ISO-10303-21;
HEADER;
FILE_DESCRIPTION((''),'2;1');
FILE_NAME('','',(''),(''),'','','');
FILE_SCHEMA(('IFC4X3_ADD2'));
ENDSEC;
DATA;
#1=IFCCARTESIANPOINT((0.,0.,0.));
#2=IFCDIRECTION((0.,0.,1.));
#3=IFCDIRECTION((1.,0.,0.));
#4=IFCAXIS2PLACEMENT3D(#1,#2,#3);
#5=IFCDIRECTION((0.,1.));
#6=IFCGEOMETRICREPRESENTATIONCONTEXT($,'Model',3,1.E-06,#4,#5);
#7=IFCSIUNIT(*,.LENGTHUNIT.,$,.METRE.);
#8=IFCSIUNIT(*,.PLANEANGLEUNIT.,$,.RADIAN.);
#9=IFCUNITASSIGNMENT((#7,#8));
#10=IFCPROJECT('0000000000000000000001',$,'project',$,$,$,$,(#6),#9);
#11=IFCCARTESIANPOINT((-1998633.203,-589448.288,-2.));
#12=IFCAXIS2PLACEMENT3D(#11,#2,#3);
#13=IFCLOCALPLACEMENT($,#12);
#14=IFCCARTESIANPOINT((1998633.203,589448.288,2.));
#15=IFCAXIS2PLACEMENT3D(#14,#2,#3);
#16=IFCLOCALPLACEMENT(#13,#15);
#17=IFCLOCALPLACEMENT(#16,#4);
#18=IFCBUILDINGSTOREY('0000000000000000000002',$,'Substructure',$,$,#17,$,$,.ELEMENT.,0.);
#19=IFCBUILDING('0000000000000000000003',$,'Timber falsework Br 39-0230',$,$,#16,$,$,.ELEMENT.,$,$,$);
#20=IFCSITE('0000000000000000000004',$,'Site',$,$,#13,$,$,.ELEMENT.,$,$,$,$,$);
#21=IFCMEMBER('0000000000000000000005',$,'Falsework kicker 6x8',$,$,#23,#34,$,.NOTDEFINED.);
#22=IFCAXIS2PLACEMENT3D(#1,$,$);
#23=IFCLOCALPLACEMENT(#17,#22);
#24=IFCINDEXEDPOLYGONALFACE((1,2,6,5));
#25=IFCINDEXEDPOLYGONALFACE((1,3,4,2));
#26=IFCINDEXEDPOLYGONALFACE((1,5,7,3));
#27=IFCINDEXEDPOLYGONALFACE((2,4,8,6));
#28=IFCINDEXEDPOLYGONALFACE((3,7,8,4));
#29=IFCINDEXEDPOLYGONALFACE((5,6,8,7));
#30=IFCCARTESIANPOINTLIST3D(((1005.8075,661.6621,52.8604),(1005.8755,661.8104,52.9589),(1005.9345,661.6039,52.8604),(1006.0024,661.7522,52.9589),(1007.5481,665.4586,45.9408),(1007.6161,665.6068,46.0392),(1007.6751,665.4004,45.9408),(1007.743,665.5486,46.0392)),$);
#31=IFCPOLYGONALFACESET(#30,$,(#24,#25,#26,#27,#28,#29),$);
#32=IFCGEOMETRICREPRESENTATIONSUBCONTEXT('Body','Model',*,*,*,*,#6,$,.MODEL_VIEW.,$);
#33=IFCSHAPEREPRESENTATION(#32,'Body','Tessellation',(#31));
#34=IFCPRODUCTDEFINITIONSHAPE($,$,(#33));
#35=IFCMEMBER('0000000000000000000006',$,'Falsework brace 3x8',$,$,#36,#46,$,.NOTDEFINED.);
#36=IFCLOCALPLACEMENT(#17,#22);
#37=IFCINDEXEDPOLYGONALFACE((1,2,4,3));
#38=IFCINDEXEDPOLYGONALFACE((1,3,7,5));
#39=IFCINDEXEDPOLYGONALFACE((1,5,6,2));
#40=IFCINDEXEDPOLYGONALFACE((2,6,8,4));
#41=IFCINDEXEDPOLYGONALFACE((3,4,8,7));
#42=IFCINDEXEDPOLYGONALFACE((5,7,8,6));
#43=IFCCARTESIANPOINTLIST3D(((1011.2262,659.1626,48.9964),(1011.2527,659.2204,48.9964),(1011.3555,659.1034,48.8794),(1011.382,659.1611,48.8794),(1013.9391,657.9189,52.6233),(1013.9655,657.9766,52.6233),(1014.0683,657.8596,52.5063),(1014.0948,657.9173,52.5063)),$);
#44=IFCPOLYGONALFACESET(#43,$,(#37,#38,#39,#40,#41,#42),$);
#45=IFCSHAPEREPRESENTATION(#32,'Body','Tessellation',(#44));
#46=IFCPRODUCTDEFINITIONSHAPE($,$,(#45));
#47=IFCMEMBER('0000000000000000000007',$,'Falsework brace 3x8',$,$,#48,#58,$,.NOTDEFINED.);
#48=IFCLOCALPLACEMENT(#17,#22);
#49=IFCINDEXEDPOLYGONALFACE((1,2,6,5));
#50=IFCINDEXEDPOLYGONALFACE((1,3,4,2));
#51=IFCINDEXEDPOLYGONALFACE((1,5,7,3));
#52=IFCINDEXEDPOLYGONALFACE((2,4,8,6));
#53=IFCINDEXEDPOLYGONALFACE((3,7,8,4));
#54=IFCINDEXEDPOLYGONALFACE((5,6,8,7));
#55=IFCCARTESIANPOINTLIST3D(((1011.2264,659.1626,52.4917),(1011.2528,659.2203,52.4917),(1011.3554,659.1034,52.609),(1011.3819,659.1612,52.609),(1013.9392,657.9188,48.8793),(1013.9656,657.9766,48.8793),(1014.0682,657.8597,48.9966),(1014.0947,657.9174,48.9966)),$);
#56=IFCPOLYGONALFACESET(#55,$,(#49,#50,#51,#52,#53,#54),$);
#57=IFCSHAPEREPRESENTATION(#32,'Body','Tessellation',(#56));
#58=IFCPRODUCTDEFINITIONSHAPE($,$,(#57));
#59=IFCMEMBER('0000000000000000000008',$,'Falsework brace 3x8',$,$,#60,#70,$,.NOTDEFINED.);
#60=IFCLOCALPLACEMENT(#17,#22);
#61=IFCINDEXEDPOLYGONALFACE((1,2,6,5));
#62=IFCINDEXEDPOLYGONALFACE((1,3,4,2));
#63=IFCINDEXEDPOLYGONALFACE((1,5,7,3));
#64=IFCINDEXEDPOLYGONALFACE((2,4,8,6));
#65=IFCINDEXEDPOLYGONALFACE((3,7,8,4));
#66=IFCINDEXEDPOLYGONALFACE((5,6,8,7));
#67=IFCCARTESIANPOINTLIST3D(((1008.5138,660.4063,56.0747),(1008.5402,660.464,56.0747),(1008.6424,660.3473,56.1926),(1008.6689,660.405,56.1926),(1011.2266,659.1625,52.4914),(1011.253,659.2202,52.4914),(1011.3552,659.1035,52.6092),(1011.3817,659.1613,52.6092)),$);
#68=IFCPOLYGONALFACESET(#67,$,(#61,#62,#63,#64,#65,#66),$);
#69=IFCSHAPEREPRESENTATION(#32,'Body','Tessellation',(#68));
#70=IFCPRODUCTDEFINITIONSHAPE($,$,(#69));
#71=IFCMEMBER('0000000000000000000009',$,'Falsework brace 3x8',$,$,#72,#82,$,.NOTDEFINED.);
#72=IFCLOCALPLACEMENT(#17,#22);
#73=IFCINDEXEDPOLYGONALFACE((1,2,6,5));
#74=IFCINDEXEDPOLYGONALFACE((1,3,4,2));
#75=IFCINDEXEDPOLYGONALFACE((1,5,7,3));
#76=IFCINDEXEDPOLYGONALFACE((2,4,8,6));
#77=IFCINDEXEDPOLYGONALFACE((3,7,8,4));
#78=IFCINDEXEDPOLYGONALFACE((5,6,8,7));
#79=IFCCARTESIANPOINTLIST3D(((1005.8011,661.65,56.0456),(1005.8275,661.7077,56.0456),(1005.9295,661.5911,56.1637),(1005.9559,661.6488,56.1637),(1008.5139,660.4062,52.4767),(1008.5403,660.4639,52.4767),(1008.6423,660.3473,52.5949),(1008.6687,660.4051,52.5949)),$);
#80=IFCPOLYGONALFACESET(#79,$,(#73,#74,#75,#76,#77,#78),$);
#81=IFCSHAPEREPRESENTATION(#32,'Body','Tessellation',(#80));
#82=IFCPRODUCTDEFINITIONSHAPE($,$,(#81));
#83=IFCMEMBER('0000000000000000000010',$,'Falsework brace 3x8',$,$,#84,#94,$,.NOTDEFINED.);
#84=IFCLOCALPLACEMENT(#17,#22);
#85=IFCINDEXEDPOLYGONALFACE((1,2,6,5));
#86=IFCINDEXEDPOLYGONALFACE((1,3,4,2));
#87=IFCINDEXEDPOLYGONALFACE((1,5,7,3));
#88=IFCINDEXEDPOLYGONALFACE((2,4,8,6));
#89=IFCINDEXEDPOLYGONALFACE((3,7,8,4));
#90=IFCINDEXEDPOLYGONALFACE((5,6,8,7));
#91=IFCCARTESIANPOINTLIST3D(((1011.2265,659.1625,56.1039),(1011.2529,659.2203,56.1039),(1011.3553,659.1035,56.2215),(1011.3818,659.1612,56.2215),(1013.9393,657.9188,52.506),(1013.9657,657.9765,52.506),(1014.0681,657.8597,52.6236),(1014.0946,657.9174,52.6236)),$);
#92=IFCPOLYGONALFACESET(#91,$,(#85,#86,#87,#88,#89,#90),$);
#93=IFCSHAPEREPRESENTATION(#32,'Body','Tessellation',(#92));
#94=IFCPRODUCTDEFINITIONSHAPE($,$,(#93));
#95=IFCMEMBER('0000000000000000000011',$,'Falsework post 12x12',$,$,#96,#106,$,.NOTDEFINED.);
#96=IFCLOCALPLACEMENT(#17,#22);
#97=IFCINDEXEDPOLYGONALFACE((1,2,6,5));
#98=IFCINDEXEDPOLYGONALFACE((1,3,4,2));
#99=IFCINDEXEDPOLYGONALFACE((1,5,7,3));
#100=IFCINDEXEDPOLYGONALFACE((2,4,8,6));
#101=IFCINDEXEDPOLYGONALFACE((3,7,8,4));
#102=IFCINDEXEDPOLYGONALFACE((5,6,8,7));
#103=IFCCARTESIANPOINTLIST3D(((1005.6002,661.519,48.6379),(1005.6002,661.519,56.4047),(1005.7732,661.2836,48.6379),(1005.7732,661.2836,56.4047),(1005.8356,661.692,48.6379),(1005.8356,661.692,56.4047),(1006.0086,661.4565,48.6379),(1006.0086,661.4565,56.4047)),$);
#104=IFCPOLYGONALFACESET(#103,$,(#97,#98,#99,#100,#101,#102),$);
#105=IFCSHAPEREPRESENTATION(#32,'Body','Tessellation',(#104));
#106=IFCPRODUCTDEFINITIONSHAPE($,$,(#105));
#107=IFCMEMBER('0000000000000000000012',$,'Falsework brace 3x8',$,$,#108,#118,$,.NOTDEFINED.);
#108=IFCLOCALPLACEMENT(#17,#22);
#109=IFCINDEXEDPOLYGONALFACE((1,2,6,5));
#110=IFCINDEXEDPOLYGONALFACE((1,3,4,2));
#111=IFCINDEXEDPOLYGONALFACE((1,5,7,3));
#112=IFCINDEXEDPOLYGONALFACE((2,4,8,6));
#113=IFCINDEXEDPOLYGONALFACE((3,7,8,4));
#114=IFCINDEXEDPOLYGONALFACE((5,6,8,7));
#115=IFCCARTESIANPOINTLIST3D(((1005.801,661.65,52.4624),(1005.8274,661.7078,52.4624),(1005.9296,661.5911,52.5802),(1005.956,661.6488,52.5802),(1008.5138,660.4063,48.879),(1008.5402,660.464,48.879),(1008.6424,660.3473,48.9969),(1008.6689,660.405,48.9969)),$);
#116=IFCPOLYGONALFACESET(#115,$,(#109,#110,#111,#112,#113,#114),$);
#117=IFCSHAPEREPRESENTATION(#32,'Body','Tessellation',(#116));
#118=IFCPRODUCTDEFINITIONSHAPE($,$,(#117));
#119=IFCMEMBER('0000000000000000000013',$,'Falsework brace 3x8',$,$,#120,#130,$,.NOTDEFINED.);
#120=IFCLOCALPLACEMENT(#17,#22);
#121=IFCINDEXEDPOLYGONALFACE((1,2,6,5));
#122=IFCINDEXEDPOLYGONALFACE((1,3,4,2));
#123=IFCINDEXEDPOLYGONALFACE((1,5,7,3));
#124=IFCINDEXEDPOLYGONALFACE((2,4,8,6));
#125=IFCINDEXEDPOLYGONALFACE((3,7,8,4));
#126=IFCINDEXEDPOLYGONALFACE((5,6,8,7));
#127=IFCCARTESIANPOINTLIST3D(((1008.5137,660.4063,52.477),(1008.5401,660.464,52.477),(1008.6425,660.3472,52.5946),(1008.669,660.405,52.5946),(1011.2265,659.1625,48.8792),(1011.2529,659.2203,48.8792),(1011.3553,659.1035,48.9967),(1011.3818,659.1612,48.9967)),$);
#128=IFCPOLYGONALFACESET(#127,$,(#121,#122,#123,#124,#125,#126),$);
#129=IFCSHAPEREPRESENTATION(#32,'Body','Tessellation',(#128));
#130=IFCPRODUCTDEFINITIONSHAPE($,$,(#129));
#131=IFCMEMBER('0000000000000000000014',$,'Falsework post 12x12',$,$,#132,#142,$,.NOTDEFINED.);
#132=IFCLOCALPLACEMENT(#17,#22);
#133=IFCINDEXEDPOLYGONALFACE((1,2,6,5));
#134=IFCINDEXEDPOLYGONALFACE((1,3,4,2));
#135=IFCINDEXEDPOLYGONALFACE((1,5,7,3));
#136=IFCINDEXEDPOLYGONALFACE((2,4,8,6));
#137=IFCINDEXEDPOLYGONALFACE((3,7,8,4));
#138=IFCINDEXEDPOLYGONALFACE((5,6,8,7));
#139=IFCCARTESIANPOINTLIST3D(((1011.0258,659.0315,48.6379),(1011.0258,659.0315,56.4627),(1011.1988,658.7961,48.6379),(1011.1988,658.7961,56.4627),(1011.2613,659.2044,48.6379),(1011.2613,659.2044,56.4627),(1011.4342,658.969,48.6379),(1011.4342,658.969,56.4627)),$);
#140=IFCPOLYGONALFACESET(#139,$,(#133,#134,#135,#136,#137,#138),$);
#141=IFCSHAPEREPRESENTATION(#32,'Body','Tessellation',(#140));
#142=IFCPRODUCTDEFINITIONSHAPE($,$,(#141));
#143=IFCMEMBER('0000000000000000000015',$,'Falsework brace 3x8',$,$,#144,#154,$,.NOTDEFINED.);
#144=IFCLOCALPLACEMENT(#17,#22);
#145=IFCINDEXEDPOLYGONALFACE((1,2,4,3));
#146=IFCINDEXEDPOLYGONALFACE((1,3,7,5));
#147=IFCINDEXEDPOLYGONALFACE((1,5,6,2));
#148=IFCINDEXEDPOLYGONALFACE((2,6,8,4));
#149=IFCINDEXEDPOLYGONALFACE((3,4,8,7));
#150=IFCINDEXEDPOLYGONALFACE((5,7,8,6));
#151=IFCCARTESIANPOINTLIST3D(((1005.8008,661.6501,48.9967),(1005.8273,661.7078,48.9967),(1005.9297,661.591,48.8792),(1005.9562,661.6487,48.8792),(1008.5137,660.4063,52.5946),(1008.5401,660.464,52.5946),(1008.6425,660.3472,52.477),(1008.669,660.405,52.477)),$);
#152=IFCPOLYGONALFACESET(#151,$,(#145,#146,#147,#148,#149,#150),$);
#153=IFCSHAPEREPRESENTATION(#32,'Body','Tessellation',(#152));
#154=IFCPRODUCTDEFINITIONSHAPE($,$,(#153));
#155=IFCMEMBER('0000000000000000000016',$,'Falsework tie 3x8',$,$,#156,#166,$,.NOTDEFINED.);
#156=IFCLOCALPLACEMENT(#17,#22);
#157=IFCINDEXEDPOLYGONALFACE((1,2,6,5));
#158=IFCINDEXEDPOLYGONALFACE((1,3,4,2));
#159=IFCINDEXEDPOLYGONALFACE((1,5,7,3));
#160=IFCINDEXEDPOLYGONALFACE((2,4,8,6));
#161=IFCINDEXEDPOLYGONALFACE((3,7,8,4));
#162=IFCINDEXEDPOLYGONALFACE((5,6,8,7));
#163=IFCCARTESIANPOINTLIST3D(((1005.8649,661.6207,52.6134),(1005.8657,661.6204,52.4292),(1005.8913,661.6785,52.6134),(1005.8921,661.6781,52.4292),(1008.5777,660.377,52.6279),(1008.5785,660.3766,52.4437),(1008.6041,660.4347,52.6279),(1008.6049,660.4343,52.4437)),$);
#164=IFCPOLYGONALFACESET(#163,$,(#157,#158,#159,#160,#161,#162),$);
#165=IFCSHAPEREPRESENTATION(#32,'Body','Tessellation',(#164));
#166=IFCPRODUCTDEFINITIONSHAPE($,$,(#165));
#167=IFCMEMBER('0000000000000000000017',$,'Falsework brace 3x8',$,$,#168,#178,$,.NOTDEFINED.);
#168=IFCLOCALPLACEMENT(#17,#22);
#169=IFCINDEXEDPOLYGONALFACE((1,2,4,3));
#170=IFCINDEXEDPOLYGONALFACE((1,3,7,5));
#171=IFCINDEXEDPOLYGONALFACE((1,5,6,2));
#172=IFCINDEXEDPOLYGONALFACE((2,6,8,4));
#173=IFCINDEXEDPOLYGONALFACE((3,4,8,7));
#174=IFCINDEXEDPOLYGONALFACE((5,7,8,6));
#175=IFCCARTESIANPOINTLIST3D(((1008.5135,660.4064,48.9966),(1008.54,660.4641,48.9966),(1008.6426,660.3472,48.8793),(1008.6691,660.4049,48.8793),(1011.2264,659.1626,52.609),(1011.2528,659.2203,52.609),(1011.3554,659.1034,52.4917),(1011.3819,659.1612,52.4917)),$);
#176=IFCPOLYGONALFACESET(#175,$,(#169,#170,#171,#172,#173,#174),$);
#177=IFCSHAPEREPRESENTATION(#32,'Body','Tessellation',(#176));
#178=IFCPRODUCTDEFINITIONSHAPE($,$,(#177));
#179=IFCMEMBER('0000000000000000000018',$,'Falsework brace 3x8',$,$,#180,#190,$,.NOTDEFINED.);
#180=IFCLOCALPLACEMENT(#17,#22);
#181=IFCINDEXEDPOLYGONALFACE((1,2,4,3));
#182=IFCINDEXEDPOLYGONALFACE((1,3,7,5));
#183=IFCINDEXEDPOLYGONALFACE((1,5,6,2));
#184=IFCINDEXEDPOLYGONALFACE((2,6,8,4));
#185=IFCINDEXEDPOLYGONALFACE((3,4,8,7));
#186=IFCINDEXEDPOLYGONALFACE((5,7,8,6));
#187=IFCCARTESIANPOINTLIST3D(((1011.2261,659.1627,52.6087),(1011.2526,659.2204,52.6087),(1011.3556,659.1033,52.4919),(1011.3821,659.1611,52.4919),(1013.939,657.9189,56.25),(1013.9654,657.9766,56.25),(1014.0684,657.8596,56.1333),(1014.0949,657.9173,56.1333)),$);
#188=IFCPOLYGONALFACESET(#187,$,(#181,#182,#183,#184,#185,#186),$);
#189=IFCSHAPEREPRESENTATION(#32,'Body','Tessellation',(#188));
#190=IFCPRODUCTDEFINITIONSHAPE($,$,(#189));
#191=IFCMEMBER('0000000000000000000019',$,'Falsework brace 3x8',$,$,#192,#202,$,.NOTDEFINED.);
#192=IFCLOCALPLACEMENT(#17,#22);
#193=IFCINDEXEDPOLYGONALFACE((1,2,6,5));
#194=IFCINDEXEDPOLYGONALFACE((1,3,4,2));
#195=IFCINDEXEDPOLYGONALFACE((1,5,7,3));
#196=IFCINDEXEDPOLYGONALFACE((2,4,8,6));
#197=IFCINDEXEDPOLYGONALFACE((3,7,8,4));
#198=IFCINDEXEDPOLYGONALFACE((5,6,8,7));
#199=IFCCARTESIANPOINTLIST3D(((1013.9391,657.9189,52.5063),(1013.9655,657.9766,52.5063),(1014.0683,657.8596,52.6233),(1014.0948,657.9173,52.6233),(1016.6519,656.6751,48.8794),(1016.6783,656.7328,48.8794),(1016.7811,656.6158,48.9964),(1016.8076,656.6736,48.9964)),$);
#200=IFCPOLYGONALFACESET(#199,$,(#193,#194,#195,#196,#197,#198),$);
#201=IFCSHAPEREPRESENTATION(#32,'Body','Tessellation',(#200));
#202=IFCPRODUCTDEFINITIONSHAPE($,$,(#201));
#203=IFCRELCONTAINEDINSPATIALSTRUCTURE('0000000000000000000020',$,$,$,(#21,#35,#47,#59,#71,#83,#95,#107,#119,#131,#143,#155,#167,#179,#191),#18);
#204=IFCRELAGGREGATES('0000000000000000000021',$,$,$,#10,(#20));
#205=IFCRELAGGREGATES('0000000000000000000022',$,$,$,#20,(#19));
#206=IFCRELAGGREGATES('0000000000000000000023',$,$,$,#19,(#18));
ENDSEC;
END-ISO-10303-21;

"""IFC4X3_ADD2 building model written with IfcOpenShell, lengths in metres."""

from ifc_helpers import new_model, si_unit, direction, frame, origin, origin_with_axes, origin_2d, place, context, subcontext, project, spatial, rectangle, extrude, element, save


model = new_model("IFC4X3_ADD2")

# Units and contexts
model_context = context("Model", 3, precision=1e-06, world=origin_with_axes(), true_north=direction((0.0, 1.0)))
body_context = subcontext(model_context, "Body", "Model", "MODEL_VIEW")
ifc_project = project(units=[si_unit("LENGTHUNIT", "METRE"), si_unit("PLANEANGLEUNIT", "RADIAN")], contexts=[model_context])

# Site, building, storey
site_placement = place(None, frame((-1998633.203, -589448.288, -2.0), z_axis=(0.0, 0.0, 1.0), x_axis=(1.0, 0.0, 0.0)))
site = spatial("IfcSite", under=ifc_project, at=site_placement, Name="Site", CompositionType="ELEMENT")
building_placement = place(site_placement, frame((1998633.203, 589448.288, 2.0), z_axis=(0.0, 0.0, 1.0), x_axis=(1.0, 0.0, 0.0)))
building = spatial("IfcBuilding", under=site, at=building_placement, Name="Timber falsework Br 39-0230", CompositionType="ELEMENT")
storey_placement = place(building_placement, origin_with_axes())
storey = spatial("IfcBuildingStorey", under=building, at=storey_placement, Name="Substructure", CompositionType="ELEMENT", Elevation=0.0)

# Members
member_1_placement = place(storey_placement, frame((1005.905, 661.7071, 52.9096), z_axis=(0.215358, 0.469722, -0.856144), x_axis=(-0.909014, 0.416765, 0.0)))
element("IfcMember", 1, at=member_1_placement, inside=storey, Name="Falsework kicker 6x8", PredefinedType="NOTDEFINED", context=body_context, shape_type="SweptSolid", body=[
    extrude(rectangle(XDim=0.1397, YDim=0.1905, at=origin_2d()), origin(), (0.0, 0.0, 1.0), 8.0823),
])
member_2_placement = place(storey_placement, frame((1011.3041, 659.1619, 48.9379), z_axis=(0.57758, -0.264809, 0.77219), x_axis=(0.416765, 0.909014, 0.0)))
element("IfcMember", 2, at=member_2_placement, inside=storey, Name="Falsework brace 3x8", PredefinedType="NOTDEFINED", context=body_context, shape_type="SweptSolid", body=[
    extrude(rectangle(XDim=0.0635, YDim=0.1841, at=origin_2d()), origin(), (0.0, 0.0, 1.0), 4.6969),
])
member_3_placement = place(storey_placement, frame((1011.3041, 659.1619, 52.5503), z_axis=(0.578959, -0.265441, -0.77094), x_axis=(0.416765, 0.909014, 0.0)))
element("IfcMember", 3, at=member_3_placement, inside=storey, Name="Falsework brace 3x8", PredefinedType="NOTDEFINED", context=body_context, shape_type="SweptSolid", body=[
    extrude(rectangle(XDim=0.0635, YDim=0.1841, at=origin_2d()), origin(), (0.0, 0.0, 1.0), 4.6857),
])
member_4_placement = place(storey_placement, frame((1008.5913, 660.4056, 56.1337), z_axis=(0.58173, -0.266712, -0.768411), x_axis=(0.416765, 0.909014, 0.0)))
element("IfcMember", 4, at=member_4_placement, inside=storey, Name="Falsework brace 3x8", PredefinedType="NOTDEFINED", context=body_context, shape_type="SweptSolid", body=[
    extrude(rectangle(XDim=0.0635, YDim=0.1841, at=origin_2d()), origin(), (0.0, 0.0, 1.0), 4.6633),
])
member_5_placement = place(storey_placement, frame((1005.8785, 661.6494, 56.1047), z_axis=(0.583122, -0.26735, -0.767133), x_axis=(0.416765, 0.909014, 0.0)))
element("IfcMember", 5, at=member_5_placement, inside=storey, Name="Falsework brace 3x8", PredefinedType="NOTDEFINED", context=body_context, shape_type="SweptSolid", body=[
    extrude(rectangle(XDim=0.0635, YDim=0.1841, at=origin_2d()), origin(), (0.0, 0.0, 1.0), 4.6522),
])
member_6_placement = place(storey_placement, frame((1011.3041, 659.1619, 56.1627), z_axis=(0.580342, -0.266075, -0.76968), x_axis=(0.416765, 0.909014, 0.0)))
element("IfcMember", 6, at=member_6_placement, inside=storey, Name="Falsework brace 3x8", PredefinedType="NOTDEFINED", context=body_context, shape_type="SweptSolid", body=[
    extrude(rectangle(XDim=0.0635, YDim=0.1841, at=origin_2d()), origin(), (0.0, 0.0, 1.0), 4.6745),
])
member_7_placement = place(storey_placement, frame((1005.8044, 661.4878, 48.6379), z_axis=(0.0, 0.0, 1.0), x_axis=(-0.805928, -0.592013, 0.0)))
element("IfcMember", 7, at=member_7_placement, inside=storey, Name="Falsework post 12x12", PredefinedType="NOTDEFINED", context=body_context, shape_type="SweptSolid", body=[
    extrude(rectangle(XDim=0.2921, YDim=0.2921, at=origin_2d()), origin(), (0.0, 0.0, 1.0), 7.7667),
])
member_8_placement = place(storey_placement, frame((1005.8785, 661.6494, 52.5213), z_axis=(0.58173, -0.266712, -0.768411), x_axis=(0.416765, 0.909014, 0.0)))
element("IfcMember", 8, at=member_8_placement, inside=storey, Name="Falsework brace 3x8", PredefinedType="NOTDEFINED", context=body_context, shape_type="SweptSolid", body=[
    extrude(rectangle(XDim=0.0635, YDim=0.1841, at=origin_2d()), origin(), (0.0, 0.0, 1.0), 4.6633),
])
member_9_placement = place(storey_placement, frame((1008.5913, 660.4056, 52.5358), z_axis=(0.580342, -0.266075, -0.76968), x_axis=(0.416765, 0.909014, 0.0)))
element("IfcMember", 9, at=member_9_placement, inside=storey, Name="Falsework brace 3x8", PredefinedType="NOTDEFINED", context=body_context, shape_type="SweptSolid", body=[
    extrude(rectangle(XDim=0.0635, YDim=0.1841, at=origin_2d()), origin(), (0.0, 0.0, 1.0), 4.6745),
])
member_10_placement = place(storey_placement, frame((1011.23, 659.0003, 48.6379), z_axis=(0.0, 0.0, 1.0), x_axis=(-0.805928, -0.592013, 0.0)))
element("IfcMember", 10, at=member_10_placement, inside=storey, Name="Falsework post 12x12", PredefinedType="NOTDEFINED", context=body_context, shape_type="SweptSolid", body=[
    extrude(rectangle(XDim=0.2921, YDim=0.2921, at=origin_2d()), origin(), (0.0, 0.0, 1.0), 7.8247),
])
member_11_placement = place(storey_placement, frame((1005.8785, 661.6494, 48.9379), z_axis=(0.580342, -0.266075, 0.76968), x_axis=(0.416765, 0.909014, 0.0)))
element("IfcMember", 11, at=member_11_placement, inside=storey, Name="Falsework brace 3x8", PredefinedType="NOTDEFINED", context=body_context, shape_type="SweptSolid", body=[
    extrude(rectangle(XDim=0.0635, YDim=0.1841, at=origin_2d()), origin(), (0.0, 0.0, 1.0), 4.6745),
])
member_12_placement = place(storey_placement, frame((1005.8785, 661.6494, 52.5213), z_axis=(0.909003, -0.41676, 0.004859), x_axis=(0.416765, 0.909014, 0.0)))
element("IfcMember", 12, at=member_12_placement, inside=storey, Name="Falsework tie 3x8", PredefinedType="NOTDEFINED", context=body_context, shape_type="SweptSolid", body=[
    extrude(rectangle(XDim=0.0635, YDim=0.1841, at=origin_2d()), origin(), (0.0, 0.0, 1.0), 2.9844),
])
member_13_placement = place(storey_placement, frame((1008.5913, 660.4056, 48.9379), z_axis=(0.578959, -0.265441, 0.77094), x_axis=(0.416765, 0.909014, 0.0)))
element("IfcMember", 13, at=member_13_placement, inside=storey, Name="Falsework brace 3x8", PredefinedType="NOTDEFINED", context=body_context, shape_type="SweptSolid", body=[
    extrude(rectangle(XDim=0.0635, YDim=0.1841, at=origin_2d()), origin(), (0.0, 0.0, 1.0), 4.6857),
])
member_14_placement = place(storey_placement, frame((1011.3041, 659.1619, 52.5503), z_axis=(0.576205, -0.264179, 0.773432), x_axis=(0.416765, 0.909014, 0.0)))
element("IfcMember", 14, at=member_14_placement, inside=storey, Name="Falsework brace 3x8", PredefinedType="NOTDEFINED", context=body_context, shape_type="SweptSolid", body=[
    extrude(rectangle(XDim=0.0635, YDim=0.1841, at=origin_2d()), origin(), (0.0, 0.0, 1.0), 4.7081),
])
member_15_placement = place(storey_placement, frame((1014.0169, 657.9181, 52.5648), z_axis=(0.57758, -0.264809, -0.77219), x_axis=(0.416765, 0.909014, 0.0)))
element("IfcMember", 15, at=member_15_placement, inside=storey, Name="Falsework brace 3x8", PredefinedType="NOTDEFINED", context=body_context, shape_type="SweptSolid", body=[
    extrude(rectangle(XDim=0.0635, YDim=0.1841, at=origin_2d()), origin(), (0.0, 0.0, 1.0), 4.6969),
])

save(model, "model.ifc")
